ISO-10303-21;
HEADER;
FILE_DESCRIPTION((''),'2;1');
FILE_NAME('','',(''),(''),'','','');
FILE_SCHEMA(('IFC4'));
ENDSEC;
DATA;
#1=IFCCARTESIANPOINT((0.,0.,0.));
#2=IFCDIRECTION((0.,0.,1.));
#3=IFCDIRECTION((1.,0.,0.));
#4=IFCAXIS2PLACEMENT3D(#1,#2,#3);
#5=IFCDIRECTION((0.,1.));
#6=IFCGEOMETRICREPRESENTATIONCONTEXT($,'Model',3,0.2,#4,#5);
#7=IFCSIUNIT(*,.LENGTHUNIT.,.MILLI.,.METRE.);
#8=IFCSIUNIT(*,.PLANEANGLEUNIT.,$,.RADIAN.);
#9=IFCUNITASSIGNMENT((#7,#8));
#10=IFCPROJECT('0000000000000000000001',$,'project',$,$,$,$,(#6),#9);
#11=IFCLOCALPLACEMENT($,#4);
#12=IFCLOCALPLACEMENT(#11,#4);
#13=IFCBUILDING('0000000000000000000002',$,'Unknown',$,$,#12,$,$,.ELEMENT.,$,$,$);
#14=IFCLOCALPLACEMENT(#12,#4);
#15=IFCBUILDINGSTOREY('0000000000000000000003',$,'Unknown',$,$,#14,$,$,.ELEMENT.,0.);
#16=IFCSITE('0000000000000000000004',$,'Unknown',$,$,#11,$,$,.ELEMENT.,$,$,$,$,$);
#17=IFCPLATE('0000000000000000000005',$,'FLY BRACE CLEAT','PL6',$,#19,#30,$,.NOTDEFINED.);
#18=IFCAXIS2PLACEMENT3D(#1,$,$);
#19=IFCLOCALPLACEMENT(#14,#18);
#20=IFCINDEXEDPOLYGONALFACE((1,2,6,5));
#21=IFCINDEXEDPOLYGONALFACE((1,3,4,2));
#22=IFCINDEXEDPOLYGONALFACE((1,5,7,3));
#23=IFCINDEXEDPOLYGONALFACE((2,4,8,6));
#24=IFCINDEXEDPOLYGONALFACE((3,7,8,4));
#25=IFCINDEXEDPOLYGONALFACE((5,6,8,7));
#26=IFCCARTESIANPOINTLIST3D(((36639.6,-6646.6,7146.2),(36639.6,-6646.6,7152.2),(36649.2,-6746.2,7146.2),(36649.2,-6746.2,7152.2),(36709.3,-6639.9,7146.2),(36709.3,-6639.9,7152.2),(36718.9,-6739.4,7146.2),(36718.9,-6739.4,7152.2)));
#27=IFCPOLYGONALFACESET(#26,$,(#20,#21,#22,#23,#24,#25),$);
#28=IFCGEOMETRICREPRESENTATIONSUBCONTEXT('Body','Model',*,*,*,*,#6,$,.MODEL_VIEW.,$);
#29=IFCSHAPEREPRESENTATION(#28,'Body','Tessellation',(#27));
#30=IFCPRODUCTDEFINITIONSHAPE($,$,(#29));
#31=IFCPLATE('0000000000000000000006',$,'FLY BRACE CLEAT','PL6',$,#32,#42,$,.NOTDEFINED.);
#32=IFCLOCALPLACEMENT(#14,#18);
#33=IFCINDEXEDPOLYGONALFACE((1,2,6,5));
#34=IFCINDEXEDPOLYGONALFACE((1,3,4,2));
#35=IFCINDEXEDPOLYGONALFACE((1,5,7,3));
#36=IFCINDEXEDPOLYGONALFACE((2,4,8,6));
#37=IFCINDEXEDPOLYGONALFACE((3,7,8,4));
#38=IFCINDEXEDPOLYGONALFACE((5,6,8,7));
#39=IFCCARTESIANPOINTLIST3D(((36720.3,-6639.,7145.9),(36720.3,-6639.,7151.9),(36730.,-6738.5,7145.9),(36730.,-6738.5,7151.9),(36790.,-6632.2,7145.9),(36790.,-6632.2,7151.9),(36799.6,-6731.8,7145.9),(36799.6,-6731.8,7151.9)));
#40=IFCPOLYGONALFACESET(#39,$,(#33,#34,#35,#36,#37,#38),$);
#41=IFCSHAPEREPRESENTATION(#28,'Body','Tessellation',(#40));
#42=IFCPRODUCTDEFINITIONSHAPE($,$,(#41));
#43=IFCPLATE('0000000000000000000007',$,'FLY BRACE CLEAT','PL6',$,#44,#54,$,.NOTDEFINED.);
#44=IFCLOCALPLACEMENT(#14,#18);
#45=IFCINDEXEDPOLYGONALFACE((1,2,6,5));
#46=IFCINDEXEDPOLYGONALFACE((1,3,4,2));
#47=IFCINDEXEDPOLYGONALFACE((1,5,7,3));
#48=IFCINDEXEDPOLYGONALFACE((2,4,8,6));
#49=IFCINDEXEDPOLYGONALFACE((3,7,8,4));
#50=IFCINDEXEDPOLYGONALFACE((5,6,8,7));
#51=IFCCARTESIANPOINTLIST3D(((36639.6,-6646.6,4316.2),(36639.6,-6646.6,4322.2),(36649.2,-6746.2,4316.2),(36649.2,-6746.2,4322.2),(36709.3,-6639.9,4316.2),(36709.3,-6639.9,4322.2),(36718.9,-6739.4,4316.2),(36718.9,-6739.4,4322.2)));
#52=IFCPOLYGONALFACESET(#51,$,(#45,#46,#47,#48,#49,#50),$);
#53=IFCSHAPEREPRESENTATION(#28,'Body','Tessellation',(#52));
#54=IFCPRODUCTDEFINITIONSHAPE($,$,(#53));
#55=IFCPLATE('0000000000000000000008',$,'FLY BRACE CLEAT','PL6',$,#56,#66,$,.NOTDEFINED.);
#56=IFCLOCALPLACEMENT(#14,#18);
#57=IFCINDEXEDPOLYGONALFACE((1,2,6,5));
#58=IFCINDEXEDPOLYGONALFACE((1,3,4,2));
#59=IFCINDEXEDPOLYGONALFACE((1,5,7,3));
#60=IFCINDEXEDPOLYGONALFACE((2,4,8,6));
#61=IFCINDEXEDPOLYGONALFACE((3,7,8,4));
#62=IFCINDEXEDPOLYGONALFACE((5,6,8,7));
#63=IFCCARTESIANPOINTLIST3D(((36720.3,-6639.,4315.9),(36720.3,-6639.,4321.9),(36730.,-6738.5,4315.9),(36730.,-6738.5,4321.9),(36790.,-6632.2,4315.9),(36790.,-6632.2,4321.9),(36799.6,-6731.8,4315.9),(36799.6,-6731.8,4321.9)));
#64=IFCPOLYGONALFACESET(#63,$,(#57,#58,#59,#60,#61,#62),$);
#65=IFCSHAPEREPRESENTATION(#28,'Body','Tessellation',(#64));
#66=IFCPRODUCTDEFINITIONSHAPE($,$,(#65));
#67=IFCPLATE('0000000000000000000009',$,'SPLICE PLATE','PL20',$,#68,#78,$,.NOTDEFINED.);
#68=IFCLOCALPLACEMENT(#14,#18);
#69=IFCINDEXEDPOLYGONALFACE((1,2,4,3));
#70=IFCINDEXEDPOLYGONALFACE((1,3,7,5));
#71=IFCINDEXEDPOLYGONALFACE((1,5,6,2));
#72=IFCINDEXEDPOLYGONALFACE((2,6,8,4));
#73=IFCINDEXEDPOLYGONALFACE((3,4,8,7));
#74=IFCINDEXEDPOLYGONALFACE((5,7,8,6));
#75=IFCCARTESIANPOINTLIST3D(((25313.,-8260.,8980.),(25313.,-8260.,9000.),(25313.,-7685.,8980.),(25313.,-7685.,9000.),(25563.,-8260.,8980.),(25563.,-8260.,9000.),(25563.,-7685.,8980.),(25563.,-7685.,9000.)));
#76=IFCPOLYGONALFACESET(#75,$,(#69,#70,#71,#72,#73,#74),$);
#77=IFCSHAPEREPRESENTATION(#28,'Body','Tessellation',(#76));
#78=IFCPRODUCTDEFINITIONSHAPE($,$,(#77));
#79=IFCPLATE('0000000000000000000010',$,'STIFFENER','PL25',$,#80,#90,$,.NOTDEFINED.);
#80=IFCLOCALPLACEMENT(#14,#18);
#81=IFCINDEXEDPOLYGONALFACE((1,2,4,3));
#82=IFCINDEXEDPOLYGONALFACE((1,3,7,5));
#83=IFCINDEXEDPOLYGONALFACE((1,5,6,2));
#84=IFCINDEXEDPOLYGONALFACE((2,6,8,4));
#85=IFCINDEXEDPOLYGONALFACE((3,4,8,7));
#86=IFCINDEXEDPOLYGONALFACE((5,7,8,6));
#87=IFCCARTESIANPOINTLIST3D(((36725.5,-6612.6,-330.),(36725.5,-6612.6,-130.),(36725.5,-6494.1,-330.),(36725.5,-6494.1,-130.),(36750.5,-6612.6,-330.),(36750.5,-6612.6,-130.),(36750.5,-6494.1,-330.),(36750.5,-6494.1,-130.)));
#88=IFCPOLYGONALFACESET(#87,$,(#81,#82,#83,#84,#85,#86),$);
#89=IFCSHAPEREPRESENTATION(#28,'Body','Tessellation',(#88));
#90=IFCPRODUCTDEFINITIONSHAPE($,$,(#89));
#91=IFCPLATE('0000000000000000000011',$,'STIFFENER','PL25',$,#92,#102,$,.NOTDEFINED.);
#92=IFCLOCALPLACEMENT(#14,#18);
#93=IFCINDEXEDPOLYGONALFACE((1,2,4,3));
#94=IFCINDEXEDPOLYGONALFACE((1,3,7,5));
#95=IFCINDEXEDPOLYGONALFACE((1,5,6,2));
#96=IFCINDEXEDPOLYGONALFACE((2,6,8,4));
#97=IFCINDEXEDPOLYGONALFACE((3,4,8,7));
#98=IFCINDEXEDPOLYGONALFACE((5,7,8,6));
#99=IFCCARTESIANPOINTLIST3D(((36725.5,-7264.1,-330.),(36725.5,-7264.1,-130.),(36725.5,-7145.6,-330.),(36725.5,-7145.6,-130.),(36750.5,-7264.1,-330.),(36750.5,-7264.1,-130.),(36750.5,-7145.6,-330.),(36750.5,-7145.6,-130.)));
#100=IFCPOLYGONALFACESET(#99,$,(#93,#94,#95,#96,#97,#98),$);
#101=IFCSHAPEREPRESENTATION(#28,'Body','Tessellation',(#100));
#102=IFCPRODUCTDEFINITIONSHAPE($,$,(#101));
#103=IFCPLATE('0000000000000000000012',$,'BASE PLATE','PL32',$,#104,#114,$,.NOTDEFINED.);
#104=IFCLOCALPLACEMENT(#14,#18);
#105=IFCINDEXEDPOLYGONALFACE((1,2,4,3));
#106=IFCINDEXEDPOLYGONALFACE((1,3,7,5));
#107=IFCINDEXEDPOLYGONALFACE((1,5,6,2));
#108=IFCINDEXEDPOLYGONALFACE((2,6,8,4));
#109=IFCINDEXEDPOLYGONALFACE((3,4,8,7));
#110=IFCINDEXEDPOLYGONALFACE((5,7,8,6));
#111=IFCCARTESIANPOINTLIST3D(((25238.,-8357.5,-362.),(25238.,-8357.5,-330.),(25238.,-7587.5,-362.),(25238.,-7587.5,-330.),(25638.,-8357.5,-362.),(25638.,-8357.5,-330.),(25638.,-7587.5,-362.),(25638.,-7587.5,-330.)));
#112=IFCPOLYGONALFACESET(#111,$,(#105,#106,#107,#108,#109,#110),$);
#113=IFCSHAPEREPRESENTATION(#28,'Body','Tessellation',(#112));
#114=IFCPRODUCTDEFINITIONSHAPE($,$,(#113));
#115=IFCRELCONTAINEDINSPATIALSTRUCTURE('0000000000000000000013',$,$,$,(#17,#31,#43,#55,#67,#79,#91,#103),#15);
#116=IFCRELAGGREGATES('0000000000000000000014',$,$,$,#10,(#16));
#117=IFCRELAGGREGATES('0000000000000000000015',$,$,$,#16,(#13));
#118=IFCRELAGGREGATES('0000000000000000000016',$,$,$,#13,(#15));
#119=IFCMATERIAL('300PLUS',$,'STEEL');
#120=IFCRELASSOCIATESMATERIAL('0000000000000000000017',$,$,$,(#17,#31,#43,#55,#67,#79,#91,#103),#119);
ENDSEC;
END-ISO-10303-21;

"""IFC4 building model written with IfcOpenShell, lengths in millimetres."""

from ifc_helpers import new_model, si_unit, direction, frame, origin_with_axes, place, context, subcontext, project, spatial, line, indexed_curve, outline, extrude, material, element, save


model = new_model("IFC4")

# Units and contexts
model_context = context("Model", 3, precision=0.2, world=origin_with_axes(), true_north=direction((0.0, 1.0)))
body_context = subcontext(model_context, "Body", "Model", "MODEL_VIEW")
ifc_project = project(units=[si_unit("LENGTHUNIT", "METRE", prefix="MILLI"), si_unit("PLANEANGLEUNIT", "RADIAN")], contexts=[model_context])

# Site, building, storey
site_placement = place(None, origin_with_axes())
site = spatial("IfcSite", under=ifc_project, at=site_placement, Name="Unknown", CompositionType="ELEMENT")
building_placement = place(site_placement, origin_with_axes())
building = spatial("IfcBuilding", under=site, at=building_placement, Name="Unknown", CompositionType="ELEMENT")
storey_placement = place(building_placement, origin_with_axes())
storey = spatial("IfcBuildingStorey", under=building, at=storey_placement, Name="Unknown", CompositionType="ELEMENT", Elevation=0.0)

# Shared definitions
ifc_material_1 = material(Name="300PLUS", Category="STEEL")

# Plates
plate_1_placement = place(storey_placement, frame((36709.3, -6639.9, 7149.2), z_axis=(0.0, 0.0, 1.0), x_axis=(-0.995412, -0.095685, 0.0)))
element("IfcPlate", 1, at=plate_1_placement, inside=storey, material=ifc_material_1, Name="FLY BRACE CLEAT", Description="PL6", PredefinedType="NOTDEFINED", context=body_context, shape_type="SolidModel", body=[
    extrude(outline(indexed_curve([(0.0, 0.0), (70.0, 0.0), (70.0, 100.1), (0.0, 100.0)], segments=[line(1, 2, 3, 4, 1)])), frame((0.0, 0.0, 3.0), z_axis=(0.0, 0.0, 1.0), x_axis=(1.0, 0.0, 0.0)), (0.0, 0.0, -1.0), 6.0),
])
plate_2_placement = place(storey_placement, frame((36730.0, -6738.5, 7148.9), z_axis=(0.0, 0.0, 1.0), x_axis=(0.995399, 0.095821, 0.0)))
element("IfcPlate", 2, at=plate_2_placement, inside=storey, material=ifc_material_1, Name="FLY BRACE CLEAT", Description="PL6", PredefinedType="NOTDEFINED", context=body_context, shape_type="SolidModel", body=[
    extrude(outline(indexed_curve([(0.0, 0.0), (69.9, 0.0), (69.9, 100.1), (-0.1, 100.0)], segments=[line(1, 2, 3, 4, 1)])), frame((0.0, 0.0, 3.0), z_axis=(0.0, 0.0, 1.0), x_axis=(1.0, 0.0, 0.0)), (0.0, 0.0, -1.0), 6.0),
])
plate_3_placement = place(storey_placement, frame((36709.3, -6639.9, 4319.2), z_axis=(0.0, 0.0, 1.0), x_axis=(-0.995412, -0.095685, 0.0)))
element("IfcPlate", 3, at=plate_3_placement, inside=storey, material=ifc_material_1, Name="FLY BRACE CLEAT", Description="PL6", PredefinedType="NOTDEFINED", context=body_context, shape_type="SolidModel", body=[
    extrude(outline(indexed_curve([(0.0, 0.0), (70.0, 0.0), (70.0, 100.1), (0.0, 100.0)], segments=[line(1, 2, 3, 4, 1)])), frame((0.0, 0.0, 3.0), z_axis=(0.0, 0.0, 1.0), x_axis=(1.0, 0.0, 0.0)), (0.0, 0.0, -1.0), 6.0),
])
plate_4_placement = place(storey_placement, frame((36730.0, -6738.5, 4318.9), z_axis=(0.0, 0.0, 1.0), x_axis=(0.995399, 0.095821, 0.0)))
element("IfcPlate", 4, at=plate_4_placement, inside=storey, material=ifc_material_1, Name="FLY BRACE CLEAT", Description="PL6", PredefinedType="NOTDEFINED", context=body_context, shape_type="SolidModel", body=[
    extrude(outline(indexed_curve([(0.0, 0.0), (69.9, 0.0), (69.9, 100.1), (-0.1, 100.0)], segments=[line(1, 2, 3, 4, 1)])), frame((0.0, 0.0, 3.0), z_axis=(0.0, 0.0, 1.0), x_axis=(1.0, 0.0, 0.0)), (0.0, 0.0, -1.0), 6.0),
])
plate_5_placement = place(storey_placement, frame((25563.0, -8260.0, 8990.0), z_axis=(0.0, 0.0, 1.0), x_axis=(0.0, 1.0, 0.0)))
element("IfcPlate", 5, at=plate_5_placement, inside=storey, material=ifc_material_1, Name="SPLICE PLATE", Description="PL20", PredefinedType="NOTDEFINED", context=body_context, shape_type="SolidModel", body=[
    extrude(outline(indexed_curve([(0.0, 0.0), (575.0, 0.0), (575.0, 250.0), (0.0, 250.0)], segments=[line(1, 2, 3, 4, 1)])), frame((0.0, 0.0, 10.0), z_axis=(0.0, 0.0, 1.0), x_axis=(1.0, 0.0, 0.0)), (0.0, 0.0, -1.0), 20.0),
])
for number, where, z_axis, x_axis, name in (
    (6, (36738.0, -6612.6, -330.0), (1.0, 0.0, 0.0), (0.0, 1.0, 0.0), "STIFFENER"),
    (7, (36738.0, -7145.6, -130.0), (1.0, 0.0, 0.0), (0.0, -1.0, 0.0), "STIFFENER"),
):
    element("IfcPlate", number, at=place(storey_placement, frame(where, z_axis=z_axis, x_axis=x_axis)), inside=storey, material=ifc_material_1, Name=name, Description="PL25", PredefinedType="NOTDEFINED", context=body_context, shape_type="SolidModel", body=[
        extrude(outline(indexed_curve([(0.0, 0.0), (118.5, 0.0), (118.5, 200.0), (0.0, 200.0)], segments=[line(1, 2, 3, 4, 1)])), frame((0.0, 0.0, 12.5), z_axis=(0.0, 0.0, 1.0), x_axis=(1.0, 0.0, 0.0)), (0.0, 0.0, -1.0), 25.0),
    ])
plate_6_placement = place(storey_placement, frame((25638.0, -8357.5, -346.0), z_axis=(0.0, 0.0, 1.0), x_axis=(0.0, 1.0, 0.0)))
element("IfcPlate", 8, at=plate_6_placement, inside=storey, material=ifc_material_1, Name="BASE PLATE", Description="PL32", PredefinedType="NOTDEFINED", context=body_context, shape_type="SolidModel", body=[
    extrude(outline(indexed_curve([(0.0, 0.0), (770.0, 0.0), (770.0, 400.0), (0.0, 400.0)], segments=[line(1, 2, 3, 4, 1)])), frame((0.0, 0.0, 16.0), z_axis=(0.0, 0.0, 1.0), x_axis=(1.0, 0.0, 0.0)), (0.0, 0.0, -1.0), 32.0),
])

save(model, "model.ifc")
